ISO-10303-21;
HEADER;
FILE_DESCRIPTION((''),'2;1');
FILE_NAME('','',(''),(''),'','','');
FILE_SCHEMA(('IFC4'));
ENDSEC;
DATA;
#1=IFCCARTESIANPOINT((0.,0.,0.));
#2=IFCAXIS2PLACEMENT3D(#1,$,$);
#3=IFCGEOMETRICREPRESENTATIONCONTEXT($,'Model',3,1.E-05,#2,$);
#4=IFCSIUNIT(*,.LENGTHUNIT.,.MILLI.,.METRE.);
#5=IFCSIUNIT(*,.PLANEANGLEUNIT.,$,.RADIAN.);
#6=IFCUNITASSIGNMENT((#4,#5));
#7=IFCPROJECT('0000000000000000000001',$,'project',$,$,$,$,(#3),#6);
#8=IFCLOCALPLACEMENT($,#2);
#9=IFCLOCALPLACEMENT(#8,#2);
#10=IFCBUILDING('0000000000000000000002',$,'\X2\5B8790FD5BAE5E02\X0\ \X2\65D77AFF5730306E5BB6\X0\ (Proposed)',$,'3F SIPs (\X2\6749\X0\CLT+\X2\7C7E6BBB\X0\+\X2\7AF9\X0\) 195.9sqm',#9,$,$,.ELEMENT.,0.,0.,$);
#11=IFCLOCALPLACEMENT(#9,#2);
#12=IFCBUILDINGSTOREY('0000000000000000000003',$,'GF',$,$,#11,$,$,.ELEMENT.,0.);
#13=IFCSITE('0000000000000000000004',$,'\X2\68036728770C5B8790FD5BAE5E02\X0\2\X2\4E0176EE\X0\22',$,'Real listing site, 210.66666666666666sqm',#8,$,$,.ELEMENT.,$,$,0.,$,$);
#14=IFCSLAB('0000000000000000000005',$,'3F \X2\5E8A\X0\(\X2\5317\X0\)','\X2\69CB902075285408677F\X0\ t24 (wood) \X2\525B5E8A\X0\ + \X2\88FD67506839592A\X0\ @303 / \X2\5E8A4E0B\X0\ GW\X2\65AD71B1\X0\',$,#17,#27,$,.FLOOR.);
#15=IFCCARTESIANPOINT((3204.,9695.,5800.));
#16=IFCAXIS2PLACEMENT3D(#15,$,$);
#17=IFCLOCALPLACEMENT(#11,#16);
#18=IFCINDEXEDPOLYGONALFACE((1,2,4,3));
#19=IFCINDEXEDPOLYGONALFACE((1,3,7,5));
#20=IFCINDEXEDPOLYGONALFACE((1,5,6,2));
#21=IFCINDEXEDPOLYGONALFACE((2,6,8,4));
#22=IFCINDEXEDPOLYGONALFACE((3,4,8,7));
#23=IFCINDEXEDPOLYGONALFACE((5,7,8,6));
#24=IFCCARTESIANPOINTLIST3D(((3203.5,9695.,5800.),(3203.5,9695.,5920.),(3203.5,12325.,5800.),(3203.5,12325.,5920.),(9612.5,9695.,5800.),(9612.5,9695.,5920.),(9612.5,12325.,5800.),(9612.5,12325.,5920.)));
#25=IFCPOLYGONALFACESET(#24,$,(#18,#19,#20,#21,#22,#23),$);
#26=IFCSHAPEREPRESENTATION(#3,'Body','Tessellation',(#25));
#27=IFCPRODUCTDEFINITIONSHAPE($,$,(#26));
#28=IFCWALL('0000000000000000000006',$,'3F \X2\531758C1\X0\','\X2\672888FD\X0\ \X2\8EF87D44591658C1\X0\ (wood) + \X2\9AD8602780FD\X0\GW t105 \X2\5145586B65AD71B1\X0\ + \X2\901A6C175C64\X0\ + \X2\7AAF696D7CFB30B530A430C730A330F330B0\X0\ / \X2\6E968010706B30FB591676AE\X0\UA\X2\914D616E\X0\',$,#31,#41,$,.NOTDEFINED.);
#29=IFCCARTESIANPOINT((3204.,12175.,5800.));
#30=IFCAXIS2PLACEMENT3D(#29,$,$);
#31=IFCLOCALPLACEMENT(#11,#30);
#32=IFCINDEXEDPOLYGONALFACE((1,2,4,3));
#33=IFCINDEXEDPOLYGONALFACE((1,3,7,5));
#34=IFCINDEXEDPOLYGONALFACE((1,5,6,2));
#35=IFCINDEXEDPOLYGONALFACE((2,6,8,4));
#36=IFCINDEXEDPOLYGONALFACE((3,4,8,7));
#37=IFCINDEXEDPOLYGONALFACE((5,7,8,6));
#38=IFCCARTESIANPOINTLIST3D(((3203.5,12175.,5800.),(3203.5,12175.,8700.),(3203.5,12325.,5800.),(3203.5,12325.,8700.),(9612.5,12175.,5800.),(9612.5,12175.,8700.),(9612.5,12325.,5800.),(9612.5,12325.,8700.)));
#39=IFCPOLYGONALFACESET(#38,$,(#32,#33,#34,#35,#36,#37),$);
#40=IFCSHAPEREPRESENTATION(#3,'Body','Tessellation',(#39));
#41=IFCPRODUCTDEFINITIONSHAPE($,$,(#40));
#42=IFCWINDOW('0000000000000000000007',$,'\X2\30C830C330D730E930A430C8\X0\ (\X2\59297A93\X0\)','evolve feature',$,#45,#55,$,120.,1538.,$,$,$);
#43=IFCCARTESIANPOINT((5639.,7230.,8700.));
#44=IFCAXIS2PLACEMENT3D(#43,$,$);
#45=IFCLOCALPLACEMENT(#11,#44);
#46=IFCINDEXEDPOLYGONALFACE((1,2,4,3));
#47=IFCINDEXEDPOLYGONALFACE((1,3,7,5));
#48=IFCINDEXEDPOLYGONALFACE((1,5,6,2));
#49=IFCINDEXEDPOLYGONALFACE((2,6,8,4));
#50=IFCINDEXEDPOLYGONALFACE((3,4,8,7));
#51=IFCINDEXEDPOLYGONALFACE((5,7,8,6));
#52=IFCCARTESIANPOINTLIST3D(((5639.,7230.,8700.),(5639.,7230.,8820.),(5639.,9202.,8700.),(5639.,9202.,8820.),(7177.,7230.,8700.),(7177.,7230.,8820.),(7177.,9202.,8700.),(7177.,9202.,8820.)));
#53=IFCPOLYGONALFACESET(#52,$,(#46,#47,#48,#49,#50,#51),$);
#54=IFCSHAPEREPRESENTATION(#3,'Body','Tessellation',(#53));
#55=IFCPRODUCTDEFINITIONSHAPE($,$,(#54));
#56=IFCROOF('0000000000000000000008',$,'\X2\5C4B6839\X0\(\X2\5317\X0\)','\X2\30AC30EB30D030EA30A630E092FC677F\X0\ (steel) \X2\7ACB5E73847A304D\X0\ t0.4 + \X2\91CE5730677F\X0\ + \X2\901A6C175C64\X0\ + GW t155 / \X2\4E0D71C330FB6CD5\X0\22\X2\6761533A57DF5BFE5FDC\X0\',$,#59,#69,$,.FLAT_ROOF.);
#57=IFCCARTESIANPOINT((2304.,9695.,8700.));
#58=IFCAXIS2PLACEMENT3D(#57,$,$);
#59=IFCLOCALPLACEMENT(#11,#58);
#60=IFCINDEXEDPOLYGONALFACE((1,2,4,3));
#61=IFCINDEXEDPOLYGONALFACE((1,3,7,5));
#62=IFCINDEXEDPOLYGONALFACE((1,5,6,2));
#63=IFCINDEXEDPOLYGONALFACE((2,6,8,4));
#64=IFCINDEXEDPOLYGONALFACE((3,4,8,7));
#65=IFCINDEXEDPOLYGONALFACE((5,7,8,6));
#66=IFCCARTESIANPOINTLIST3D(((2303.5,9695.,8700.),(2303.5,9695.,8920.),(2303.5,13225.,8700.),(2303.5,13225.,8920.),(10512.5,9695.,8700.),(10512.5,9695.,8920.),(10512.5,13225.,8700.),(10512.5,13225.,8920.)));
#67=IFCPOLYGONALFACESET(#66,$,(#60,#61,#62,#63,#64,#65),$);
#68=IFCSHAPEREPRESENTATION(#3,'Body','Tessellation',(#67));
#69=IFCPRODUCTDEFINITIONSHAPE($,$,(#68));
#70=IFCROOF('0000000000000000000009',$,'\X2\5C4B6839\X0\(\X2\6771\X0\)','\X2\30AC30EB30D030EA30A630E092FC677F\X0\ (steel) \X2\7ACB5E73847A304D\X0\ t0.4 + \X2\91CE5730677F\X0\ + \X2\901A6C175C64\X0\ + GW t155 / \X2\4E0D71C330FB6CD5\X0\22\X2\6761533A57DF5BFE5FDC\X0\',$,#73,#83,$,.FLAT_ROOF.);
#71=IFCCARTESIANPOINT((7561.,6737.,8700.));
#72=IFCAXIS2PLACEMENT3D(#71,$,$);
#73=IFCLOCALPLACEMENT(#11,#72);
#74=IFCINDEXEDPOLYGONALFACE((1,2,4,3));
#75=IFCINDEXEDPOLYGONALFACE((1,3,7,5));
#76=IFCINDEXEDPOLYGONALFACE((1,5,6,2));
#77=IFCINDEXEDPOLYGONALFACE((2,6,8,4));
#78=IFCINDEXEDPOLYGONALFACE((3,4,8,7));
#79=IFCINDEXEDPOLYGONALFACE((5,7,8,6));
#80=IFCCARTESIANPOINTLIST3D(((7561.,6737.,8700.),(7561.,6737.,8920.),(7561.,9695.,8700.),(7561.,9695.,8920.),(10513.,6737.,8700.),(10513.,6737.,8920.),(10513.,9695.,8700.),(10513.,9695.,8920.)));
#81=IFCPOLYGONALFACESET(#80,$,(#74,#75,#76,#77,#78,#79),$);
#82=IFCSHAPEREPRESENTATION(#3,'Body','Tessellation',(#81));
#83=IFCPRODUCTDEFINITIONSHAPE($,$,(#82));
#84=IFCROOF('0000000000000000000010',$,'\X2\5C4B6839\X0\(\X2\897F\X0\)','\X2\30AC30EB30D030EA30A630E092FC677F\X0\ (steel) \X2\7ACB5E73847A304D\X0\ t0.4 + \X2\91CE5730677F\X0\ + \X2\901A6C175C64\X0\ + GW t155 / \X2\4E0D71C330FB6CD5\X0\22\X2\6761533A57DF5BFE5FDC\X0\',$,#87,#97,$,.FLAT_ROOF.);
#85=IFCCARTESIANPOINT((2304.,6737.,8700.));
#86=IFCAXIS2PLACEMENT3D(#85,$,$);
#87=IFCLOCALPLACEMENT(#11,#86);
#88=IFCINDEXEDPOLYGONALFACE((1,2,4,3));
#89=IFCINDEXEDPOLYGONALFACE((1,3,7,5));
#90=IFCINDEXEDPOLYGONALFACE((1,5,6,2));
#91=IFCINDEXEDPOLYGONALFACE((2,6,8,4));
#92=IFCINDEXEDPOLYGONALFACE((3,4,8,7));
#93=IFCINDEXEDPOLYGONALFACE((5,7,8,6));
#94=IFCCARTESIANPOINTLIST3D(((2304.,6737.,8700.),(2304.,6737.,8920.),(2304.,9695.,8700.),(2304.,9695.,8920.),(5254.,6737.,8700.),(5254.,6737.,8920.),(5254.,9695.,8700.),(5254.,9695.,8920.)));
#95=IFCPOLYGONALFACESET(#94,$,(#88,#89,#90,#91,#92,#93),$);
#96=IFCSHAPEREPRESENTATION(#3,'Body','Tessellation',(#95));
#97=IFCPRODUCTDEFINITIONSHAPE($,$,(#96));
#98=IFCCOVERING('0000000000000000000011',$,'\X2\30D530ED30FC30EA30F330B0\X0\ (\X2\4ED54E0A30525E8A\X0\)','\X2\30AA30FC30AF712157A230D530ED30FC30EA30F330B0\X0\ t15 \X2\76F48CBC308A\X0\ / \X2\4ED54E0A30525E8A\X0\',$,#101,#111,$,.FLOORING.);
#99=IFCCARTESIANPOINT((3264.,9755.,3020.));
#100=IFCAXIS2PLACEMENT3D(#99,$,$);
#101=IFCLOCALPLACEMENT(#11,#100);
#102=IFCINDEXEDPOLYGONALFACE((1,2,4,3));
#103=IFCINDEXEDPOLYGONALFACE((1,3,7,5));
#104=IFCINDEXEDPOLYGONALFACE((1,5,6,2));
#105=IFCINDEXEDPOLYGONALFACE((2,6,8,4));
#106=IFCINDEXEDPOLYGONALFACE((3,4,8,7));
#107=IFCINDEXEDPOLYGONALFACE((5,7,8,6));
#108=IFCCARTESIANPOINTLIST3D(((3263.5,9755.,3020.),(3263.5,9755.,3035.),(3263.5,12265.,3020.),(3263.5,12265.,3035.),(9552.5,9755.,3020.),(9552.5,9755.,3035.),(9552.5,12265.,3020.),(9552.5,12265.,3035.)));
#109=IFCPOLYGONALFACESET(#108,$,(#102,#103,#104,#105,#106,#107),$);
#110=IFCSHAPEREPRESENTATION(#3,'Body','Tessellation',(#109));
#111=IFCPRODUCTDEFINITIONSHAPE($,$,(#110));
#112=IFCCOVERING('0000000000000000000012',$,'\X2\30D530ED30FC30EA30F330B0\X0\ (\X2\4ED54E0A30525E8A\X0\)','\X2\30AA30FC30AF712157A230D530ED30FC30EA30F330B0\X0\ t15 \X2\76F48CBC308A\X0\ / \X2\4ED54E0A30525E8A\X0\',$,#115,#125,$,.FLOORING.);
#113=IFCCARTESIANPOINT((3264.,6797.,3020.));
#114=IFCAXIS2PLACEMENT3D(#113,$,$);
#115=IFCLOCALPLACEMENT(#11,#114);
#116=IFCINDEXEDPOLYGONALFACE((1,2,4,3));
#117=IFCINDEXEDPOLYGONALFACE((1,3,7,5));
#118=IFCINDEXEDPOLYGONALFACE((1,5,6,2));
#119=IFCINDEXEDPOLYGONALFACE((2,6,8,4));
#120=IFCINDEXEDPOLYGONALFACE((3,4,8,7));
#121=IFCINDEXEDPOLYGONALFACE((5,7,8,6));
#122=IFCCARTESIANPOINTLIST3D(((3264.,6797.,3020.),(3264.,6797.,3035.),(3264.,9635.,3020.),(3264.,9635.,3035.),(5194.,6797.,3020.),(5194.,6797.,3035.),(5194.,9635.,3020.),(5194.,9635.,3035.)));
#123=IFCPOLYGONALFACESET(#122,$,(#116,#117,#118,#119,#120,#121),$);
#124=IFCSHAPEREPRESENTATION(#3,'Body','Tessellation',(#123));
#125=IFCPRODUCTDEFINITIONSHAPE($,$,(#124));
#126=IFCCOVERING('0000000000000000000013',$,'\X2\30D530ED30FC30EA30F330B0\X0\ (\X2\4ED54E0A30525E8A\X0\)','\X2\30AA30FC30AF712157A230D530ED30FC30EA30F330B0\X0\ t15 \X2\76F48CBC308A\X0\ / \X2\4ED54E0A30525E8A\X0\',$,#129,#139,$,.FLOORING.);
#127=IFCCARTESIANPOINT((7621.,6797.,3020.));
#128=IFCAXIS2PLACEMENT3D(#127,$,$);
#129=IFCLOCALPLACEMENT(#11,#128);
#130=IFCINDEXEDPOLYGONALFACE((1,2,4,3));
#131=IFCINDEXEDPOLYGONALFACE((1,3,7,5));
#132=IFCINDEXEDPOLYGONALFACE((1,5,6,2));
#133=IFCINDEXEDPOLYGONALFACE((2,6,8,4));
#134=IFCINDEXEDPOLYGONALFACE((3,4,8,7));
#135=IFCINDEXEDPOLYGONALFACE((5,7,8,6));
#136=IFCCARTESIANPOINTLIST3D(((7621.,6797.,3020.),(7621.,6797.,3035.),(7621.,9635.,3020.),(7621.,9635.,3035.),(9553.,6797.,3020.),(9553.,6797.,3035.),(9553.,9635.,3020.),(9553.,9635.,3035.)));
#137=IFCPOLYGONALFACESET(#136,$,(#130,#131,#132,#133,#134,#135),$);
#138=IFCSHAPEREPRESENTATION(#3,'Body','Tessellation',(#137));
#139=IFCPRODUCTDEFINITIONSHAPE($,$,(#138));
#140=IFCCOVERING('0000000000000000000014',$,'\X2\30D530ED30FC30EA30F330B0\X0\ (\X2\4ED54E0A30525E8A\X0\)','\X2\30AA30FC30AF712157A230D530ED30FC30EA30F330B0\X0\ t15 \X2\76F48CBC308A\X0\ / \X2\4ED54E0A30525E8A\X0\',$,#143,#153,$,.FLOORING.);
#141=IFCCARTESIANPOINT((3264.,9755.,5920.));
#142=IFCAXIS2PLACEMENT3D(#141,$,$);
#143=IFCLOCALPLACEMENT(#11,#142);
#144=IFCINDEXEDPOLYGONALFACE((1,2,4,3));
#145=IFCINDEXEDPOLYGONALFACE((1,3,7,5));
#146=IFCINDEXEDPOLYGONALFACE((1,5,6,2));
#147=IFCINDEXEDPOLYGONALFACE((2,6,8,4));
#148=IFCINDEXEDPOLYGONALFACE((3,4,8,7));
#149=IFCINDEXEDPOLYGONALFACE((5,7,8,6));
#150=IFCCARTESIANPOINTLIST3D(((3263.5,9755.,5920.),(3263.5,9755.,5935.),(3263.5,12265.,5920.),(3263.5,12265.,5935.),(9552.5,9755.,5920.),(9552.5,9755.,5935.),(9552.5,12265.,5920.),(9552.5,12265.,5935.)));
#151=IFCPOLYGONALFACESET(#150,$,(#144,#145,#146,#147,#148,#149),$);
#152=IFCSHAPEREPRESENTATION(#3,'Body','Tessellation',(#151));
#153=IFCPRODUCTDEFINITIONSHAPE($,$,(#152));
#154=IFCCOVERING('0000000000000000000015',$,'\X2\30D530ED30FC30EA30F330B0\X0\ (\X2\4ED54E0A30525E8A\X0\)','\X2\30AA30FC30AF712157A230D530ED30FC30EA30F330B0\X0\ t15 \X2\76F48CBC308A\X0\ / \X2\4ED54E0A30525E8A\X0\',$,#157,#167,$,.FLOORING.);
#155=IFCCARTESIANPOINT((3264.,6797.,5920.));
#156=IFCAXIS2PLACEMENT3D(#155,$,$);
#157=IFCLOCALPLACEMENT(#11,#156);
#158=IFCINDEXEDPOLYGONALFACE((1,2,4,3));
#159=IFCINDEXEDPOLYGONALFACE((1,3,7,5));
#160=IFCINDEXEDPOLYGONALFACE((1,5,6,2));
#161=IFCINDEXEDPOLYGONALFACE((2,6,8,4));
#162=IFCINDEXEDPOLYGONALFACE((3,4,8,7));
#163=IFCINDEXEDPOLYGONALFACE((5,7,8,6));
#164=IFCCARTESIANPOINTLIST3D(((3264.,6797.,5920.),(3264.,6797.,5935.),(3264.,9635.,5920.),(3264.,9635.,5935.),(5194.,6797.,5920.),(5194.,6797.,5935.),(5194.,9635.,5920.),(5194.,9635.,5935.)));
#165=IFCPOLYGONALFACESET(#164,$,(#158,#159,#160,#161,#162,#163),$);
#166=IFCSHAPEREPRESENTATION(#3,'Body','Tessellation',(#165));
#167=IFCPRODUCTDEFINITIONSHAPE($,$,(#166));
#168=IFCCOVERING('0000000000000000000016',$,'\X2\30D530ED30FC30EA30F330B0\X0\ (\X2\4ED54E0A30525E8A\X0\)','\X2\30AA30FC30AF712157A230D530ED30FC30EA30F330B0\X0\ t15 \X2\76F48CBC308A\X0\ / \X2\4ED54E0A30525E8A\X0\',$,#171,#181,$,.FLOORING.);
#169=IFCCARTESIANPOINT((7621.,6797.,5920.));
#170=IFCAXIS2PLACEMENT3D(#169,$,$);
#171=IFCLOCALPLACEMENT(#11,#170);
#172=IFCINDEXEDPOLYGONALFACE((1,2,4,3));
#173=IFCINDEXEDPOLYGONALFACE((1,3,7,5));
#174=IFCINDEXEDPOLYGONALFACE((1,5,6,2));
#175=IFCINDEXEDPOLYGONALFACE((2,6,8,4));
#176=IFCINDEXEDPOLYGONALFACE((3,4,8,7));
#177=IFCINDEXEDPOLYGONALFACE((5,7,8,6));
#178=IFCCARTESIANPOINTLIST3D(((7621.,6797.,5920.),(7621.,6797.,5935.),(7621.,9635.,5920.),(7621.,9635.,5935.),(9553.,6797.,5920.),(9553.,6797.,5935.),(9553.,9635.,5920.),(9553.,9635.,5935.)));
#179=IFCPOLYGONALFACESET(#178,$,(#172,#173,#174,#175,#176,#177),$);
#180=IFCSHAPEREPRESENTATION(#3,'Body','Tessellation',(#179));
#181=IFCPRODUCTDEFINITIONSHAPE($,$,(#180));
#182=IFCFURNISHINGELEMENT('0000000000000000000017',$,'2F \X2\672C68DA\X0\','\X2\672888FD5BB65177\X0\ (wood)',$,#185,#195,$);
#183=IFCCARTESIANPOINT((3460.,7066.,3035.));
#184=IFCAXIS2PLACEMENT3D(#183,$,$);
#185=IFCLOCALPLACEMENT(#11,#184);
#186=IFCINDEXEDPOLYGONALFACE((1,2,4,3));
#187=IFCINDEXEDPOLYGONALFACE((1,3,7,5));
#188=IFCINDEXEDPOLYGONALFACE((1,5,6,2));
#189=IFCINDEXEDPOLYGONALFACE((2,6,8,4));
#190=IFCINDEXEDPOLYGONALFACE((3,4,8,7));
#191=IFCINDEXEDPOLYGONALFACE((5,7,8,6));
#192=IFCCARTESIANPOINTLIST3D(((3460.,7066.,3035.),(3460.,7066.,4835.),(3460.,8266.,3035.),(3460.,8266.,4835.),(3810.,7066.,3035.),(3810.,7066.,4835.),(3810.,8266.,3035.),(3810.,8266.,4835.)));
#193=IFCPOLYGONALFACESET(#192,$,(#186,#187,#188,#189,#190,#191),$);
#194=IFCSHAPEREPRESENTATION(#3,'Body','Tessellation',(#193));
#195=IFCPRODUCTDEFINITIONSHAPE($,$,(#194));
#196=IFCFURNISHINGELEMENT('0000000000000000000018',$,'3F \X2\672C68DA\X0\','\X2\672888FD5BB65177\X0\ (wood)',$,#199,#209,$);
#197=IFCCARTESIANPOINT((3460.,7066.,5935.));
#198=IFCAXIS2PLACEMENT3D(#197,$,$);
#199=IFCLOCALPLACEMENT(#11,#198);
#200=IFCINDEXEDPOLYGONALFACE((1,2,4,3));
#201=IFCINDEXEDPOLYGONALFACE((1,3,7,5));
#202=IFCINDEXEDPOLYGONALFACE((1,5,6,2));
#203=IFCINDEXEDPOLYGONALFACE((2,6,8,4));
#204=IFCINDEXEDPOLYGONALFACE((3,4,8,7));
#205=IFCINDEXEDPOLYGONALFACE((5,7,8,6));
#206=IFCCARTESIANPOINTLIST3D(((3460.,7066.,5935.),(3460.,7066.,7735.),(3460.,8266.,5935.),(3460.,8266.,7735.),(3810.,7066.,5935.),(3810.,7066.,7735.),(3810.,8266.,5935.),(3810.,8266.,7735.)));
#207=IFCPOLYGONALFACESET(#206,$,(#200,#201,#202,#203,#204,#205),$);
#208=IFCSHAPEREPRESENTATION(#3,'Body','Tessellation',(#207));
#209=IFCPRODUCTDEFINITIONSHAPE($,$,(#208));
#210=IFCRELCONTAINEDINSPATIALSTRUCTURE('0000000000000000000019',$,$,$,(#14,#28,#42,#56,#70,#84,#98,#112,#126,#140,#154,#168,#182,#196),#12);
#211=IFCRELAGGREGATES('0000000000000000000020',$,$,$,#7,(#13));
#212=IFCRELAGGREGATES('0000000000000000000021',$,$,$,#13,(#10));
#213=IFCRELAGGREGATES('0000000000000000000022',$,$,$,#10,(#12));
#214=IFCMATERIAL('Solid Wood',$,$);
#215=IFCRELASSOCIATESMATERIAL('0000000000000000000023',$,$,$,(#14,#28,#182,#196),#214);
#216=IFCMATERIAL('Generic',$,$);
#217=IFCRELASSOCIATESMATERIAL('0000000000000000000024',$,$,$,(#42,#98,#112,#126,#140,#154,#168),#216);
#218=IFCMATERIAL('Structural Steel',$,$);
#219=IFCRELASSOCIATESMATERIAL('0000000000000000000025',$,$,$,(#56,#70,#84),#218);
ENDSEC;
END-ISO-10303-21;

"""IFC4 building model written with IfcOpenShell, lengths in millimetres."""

from ifc_helpers import new_model, si_unit, frame, frame_2d, origin, place, context, project, spatial, rectangle, extrude, material, element, save


model = new_model("IFC4")

# Units and contexts
model_context = context("Model", 3, precision=1e-05, world=origin())
ifc_project = project(units=[si_unit("LENGTHUNIT", "METRE", prefix="MILLI"), si_unit("PLANEANGLEUNIT", "RADIAN")], contexts=[model_context])

# Site, building, storey
site_placement = place(None, origin())
site = spatial("IfcSite", under=ifc_project, at=site_placement, Name="栃木県宇都宮市2丁目22", ObjectType="Real listing site, 210.66666666666666sqm", CompositionType="ELEMENT", RefElevation=0.0)
building_placement = place(site_placement, origin())
building = spatial("IfcBuilding", under=site, at=building_placement, Name="宇都宮市 旗竿地の家 (Proposed)", ObjectType="3F SIPs (杉CLT+籾殻+竹) 195.9sqm", CompositionType="ELEMENT", ElevationOfRefHeight=0.0, ElevationOfTerrain=0.0)
storey_placement = place(building_placement, origin())
storey = spatial("IfcBuildingStorey", under=building, at=storey_placement, Name="GF", CompositionType="ELEMENT", Elevation=0.0)

# Slab
ifc_material_1 = material(Name="Solid Wood")
slab_placement = place(storey_placement, frame((3204.0, 9695.0, 5800.0)))
element("IfcSlab", 1, at=slab_placement, inside=storey, material=ifc_material_1, Name="3F 床(北)", Description="構造用合板 t24 (wood) 剛床 + 製材根太 @303 / 床下 GW断熱", PredefinedType="FLOOR", context=model_context, shape_type="SweptSolid", body=[
    extrude(rectangle(XDim=6409.0, YDim=2630.0, at=frame_2d((3204.0, 1315.0))), frame((3204.0, 9695.0, 5800.0)), (0.0, 0.0, 1.0), 120.0),
])

# Wall
wall_1_placement = place(storey_placement, frame((3204.0, 12175.0, 5800.0)))
element("IfcWall", 2, at=wall_1_placement, inside=storey, material=ifc_material_1, Name="3F 北壁", Description="木製 軸組外壁 (wood) + 高性能GW t105 充填断熱 + 通気層 + 窯業系サイディング / 準耐火・外皮UA配慮", PredefinedType="NOTDEFINED", context=model_context, shape_type="SweptSolid", body=[
    extrude(rectangle(XDim=6409.0, YDim=150.0, at=frame_2d((3204.0, 75.0))), frame((3204.0, 12175.0, 5800.0)), (0.0, 0.0, 1.0), 2900.0),
])

# Window
ifc_material_2 = material(Name="Generic")
window_1_placement = place(storey_placement, frame((5639.0, 7230.0, 8700.0)))
element("IfcWindow", 3, at=window_1_placement, inside=storey, material=ifc_material_2, Name="トップライト (天窓)", Description="evolve feature", OverallHeight=120.0, OverallWidth=1538.0, context=model_context, shape_type="SweptSolid", body=[
    extrude(rectangle(XDim=1538.0, YDim=1972.0, at=frame_2d((769.0, 986.0))), frame((5639.0, 7230.0, 8700.0)), (0.0, 0.0, 1.0), 120.0),
])

# Roofs
ifc_material_3 = material(Name="Structural Steel")
roof_1_placement = place(storey_placement, frame((2304.0, 9695.0, 8700.0)))
element("IfcRoof", 4, at=roof_1_placement, inside=storey, material=ifc_material_3, Name="屋根(北)", Description="ガルバリウム鋼板 (steel) 立平葺き t0.4 + 野地板 + 通気層 + GW t155 / 不燃・法22条区域対応", PredefinedType="FLAT_ROOF", context=model_context, shape_type="SweptSolid", body=[
    extrude(rectangle(XDim=8209.0, YDim=3530.0, at=frame_2d((4104.0, 1765.0))), frame((2304.0, 9695.0, 8700.0)), (0.0, 0.0, 1.0), 220.0),
])
roof_2_placement = place(storey_placement, frame((7561.0, 6737.0, 8700.0)))
element("IfcRoof", 5, at=roof_2_placement, inside=storey, material=ifc_material_3, Name="屋根(東)", Description="ガルバリウム鋼板 (steel) 立平葺き t0.4 + 野地板 + 通気層 + GW t155 / 不燃・法22条区域対応", PredefinedType="FLAT_ROOF", context=model_context, shape_type="SweptSolid", body=[
    extrude(rectangle(XDim=2952.0, YDim=2958.0, at=frame_2d((1476.0, 1479.0))), frame((7561.0, 6737.0, 8700.0)), (0.0, 0.0, 1.0), 220.0),
])
roof_3_placement = place(storey_placement, frame((2304.0, 6737.0, 8700.0)))
element("IfcRoof", 6, at=roof_3_placement, inside=storey, material=ifc_material_3, Name="屋根(西)", Description="ガルバリウム鋼板 (steel) 立平葺き t0.4 + 野地板 + 通気層 + GW t155 / 不燃・法22条区域対応", PredefinedType="FLAT_ROOF", context=model_context, shape_type="SweptSolid", body=[
    extrude(rectangle(XDim=2950.0, YDim=2958.0, at=frame_2d((1475.0, 1479.0))), frame((2304.0, 6737.0, 8700.0)), (0.0, 0.0, 1.0), 220.0),
])

# Coverings
covering_1_placement = place(storey_placement, frame((3264.0, 9755.0, 3020.0)))
element("IfcCovering", 7, at=covering_1_placement, inside=storey, material=ifc_material_2, Name="フローリング (仕上げ床)", Description="オーク無垢フローリング t15 直貼り / 仕上げ床", PredefinedType="FLOORING", context=model_context, shape_type="SweptSolid", body=[
    extrude(rectangle(XDim=6289.0, YDim=2510.0, at=frame_2d((3144.0, 1255.0))), frame((3264.0, 9755.0, 3020.0)), (0.0, 0.0, 1.0), 15.0),
])
covering_2_placement = place(storey_placement, frame((3264.0, 6797.0, 3020.0)))
element("IfcCovering", 8, at=covering_2_placement, inside=storey, material=ifc_material_2, Name="フローリング (仕上げ床)", Description="オーク無垢フローリング t15 直貼り / 仕上げ床", PredefinedType="FLOORING", context=model_context, shape_type="SweptSolid", body=[
    extrude(rectangle(XDim=1930.0, YDim=2838.0, at=frame_2d((965.0, 1419.0))), frame((3264.0, 6797.0, 3020.0)), (0.0, 0.0, 1.0), 15.0),
])
covering_3_placement = place(storey_placement, frame((7621.0, 6797.0, 3020.0)))
element("IfcCovering", 9, at=covering_3_placement, inside=storey, material=ifc_material_2, Name="フローリング (仕上げ床)", Description="オーク無垢フローリング t15 直貼り / 仕上げ床", PredefinedType="FLOORING", context=model_context, shape_type="SweptSolid", body=[
    extrude(rectangle(XDim=1932.0, YDim=2838.0, at=frame_2d((966.0, 1419.0))), frame((7621.0, 6797.0, 3020.0)), (0.0, 0.0, 1.0), 15.0),
])
covering_4_placement = place(storey_placement, frame((3264.0, 9755.0, 5920.0)))
element("IfcCovering", 10, at=covering_4_placement, inside=storey, material=ifc_material_2, Name="フローリング (仕上げ床)", Description="オーク無垢フローリング t15 直貼り / 仕上げ床", PredefinedType="FLOORING", context=model_context, shape_type="SweptSolid", body=[
    extrude(rectangle(XDim=6289.0, YDim=2510.0, at=frame_2d((3144.0, 1255.0))), frame((3264.0, 9755.0, 5920.0)), (0.0, 0.0, 1.0), 15.0),
])
covering_5_placement = place(storey_placement, frame((3264.0, 6797.0, 5920.0)))
element("IfcCovering", 11, at=covering_5_placement, inside=storey, material=ifc_material_2, Name="フローリング (仕上げ床)", Description="オーク無垢フローリング t15 直貼り / 仕上げ床", PredefinedType="FLOORING", context=model_context, shape_type="SweptSolid", body=[
    extrude(rectangle(XDim=1930.0, YDim=2838.0, at=frame_2d((965.0, 1419.0))), frame((3264.0, 6797.0, 5920.0)), (0.0, 0.0, 1.0), 15.0),
])
covering_6_placement = place(storey_placement, frame((7621.0, 6797.0, 5920.0)))
element("IfcCovering", 12, at=covering_6_placement, inside=storey, material=ifc_material_2, Name="フローリング (仕上げ床)", Description="オーク無垢フローリング t15 直貼り / 仕上げ床", PredefinedType="FLOORING", context=model_context, shape_type="SweptSolid", body=[
    extrude(rectangle(XDim=1932.0, YDim=2838.0, at=frame_2d((966.0, 1419.0))), frame((7621.0, 6797.0, 5920.0)), (0.0, 0.0, 1.0), 15.0),
])

# Furnishing elements
furnishing_1_placement = place(storey_placement, frame((3460.0, 7066.0, 3035.0)))
element("IfcFurnishingElement", 13, at=furnishing_1_placement, inside=storey, material=ifc_material_1, Name="2F 本棚", Description="木製家具 (wood)", context=model_context, shape_type="SweptSolid", body=[
    extrude(rectangle(XDim=350.0, YDim=1200.0, at=frame_2d((175.0, 600.0))), frame((3460.0, 7066.0, 3035.0)), (0.0, 0.0, 1.0), 1800.0),
])
furnishing_2_placement = place(storey_placement, frame((3460.0, 7066.0, 5935.0)))
element("IfcFurnishingElement", 14, at=furnishing_2_placement, inside=storey, material=ifc_material_1, Name="3F 本棚", Description="木製家具 (wood)", context=model_context, shape_type="SweptSolid", body=[
    extrude(rectangle(XDim=350.0, YDim=1200.0, at=frame_2d((175.0, 600.0))), frame((3460.0, 7066.0, 5935.0)), (0.0, 0.0, 1.0), 1800.0),
])

save(model, "model.ifc")
